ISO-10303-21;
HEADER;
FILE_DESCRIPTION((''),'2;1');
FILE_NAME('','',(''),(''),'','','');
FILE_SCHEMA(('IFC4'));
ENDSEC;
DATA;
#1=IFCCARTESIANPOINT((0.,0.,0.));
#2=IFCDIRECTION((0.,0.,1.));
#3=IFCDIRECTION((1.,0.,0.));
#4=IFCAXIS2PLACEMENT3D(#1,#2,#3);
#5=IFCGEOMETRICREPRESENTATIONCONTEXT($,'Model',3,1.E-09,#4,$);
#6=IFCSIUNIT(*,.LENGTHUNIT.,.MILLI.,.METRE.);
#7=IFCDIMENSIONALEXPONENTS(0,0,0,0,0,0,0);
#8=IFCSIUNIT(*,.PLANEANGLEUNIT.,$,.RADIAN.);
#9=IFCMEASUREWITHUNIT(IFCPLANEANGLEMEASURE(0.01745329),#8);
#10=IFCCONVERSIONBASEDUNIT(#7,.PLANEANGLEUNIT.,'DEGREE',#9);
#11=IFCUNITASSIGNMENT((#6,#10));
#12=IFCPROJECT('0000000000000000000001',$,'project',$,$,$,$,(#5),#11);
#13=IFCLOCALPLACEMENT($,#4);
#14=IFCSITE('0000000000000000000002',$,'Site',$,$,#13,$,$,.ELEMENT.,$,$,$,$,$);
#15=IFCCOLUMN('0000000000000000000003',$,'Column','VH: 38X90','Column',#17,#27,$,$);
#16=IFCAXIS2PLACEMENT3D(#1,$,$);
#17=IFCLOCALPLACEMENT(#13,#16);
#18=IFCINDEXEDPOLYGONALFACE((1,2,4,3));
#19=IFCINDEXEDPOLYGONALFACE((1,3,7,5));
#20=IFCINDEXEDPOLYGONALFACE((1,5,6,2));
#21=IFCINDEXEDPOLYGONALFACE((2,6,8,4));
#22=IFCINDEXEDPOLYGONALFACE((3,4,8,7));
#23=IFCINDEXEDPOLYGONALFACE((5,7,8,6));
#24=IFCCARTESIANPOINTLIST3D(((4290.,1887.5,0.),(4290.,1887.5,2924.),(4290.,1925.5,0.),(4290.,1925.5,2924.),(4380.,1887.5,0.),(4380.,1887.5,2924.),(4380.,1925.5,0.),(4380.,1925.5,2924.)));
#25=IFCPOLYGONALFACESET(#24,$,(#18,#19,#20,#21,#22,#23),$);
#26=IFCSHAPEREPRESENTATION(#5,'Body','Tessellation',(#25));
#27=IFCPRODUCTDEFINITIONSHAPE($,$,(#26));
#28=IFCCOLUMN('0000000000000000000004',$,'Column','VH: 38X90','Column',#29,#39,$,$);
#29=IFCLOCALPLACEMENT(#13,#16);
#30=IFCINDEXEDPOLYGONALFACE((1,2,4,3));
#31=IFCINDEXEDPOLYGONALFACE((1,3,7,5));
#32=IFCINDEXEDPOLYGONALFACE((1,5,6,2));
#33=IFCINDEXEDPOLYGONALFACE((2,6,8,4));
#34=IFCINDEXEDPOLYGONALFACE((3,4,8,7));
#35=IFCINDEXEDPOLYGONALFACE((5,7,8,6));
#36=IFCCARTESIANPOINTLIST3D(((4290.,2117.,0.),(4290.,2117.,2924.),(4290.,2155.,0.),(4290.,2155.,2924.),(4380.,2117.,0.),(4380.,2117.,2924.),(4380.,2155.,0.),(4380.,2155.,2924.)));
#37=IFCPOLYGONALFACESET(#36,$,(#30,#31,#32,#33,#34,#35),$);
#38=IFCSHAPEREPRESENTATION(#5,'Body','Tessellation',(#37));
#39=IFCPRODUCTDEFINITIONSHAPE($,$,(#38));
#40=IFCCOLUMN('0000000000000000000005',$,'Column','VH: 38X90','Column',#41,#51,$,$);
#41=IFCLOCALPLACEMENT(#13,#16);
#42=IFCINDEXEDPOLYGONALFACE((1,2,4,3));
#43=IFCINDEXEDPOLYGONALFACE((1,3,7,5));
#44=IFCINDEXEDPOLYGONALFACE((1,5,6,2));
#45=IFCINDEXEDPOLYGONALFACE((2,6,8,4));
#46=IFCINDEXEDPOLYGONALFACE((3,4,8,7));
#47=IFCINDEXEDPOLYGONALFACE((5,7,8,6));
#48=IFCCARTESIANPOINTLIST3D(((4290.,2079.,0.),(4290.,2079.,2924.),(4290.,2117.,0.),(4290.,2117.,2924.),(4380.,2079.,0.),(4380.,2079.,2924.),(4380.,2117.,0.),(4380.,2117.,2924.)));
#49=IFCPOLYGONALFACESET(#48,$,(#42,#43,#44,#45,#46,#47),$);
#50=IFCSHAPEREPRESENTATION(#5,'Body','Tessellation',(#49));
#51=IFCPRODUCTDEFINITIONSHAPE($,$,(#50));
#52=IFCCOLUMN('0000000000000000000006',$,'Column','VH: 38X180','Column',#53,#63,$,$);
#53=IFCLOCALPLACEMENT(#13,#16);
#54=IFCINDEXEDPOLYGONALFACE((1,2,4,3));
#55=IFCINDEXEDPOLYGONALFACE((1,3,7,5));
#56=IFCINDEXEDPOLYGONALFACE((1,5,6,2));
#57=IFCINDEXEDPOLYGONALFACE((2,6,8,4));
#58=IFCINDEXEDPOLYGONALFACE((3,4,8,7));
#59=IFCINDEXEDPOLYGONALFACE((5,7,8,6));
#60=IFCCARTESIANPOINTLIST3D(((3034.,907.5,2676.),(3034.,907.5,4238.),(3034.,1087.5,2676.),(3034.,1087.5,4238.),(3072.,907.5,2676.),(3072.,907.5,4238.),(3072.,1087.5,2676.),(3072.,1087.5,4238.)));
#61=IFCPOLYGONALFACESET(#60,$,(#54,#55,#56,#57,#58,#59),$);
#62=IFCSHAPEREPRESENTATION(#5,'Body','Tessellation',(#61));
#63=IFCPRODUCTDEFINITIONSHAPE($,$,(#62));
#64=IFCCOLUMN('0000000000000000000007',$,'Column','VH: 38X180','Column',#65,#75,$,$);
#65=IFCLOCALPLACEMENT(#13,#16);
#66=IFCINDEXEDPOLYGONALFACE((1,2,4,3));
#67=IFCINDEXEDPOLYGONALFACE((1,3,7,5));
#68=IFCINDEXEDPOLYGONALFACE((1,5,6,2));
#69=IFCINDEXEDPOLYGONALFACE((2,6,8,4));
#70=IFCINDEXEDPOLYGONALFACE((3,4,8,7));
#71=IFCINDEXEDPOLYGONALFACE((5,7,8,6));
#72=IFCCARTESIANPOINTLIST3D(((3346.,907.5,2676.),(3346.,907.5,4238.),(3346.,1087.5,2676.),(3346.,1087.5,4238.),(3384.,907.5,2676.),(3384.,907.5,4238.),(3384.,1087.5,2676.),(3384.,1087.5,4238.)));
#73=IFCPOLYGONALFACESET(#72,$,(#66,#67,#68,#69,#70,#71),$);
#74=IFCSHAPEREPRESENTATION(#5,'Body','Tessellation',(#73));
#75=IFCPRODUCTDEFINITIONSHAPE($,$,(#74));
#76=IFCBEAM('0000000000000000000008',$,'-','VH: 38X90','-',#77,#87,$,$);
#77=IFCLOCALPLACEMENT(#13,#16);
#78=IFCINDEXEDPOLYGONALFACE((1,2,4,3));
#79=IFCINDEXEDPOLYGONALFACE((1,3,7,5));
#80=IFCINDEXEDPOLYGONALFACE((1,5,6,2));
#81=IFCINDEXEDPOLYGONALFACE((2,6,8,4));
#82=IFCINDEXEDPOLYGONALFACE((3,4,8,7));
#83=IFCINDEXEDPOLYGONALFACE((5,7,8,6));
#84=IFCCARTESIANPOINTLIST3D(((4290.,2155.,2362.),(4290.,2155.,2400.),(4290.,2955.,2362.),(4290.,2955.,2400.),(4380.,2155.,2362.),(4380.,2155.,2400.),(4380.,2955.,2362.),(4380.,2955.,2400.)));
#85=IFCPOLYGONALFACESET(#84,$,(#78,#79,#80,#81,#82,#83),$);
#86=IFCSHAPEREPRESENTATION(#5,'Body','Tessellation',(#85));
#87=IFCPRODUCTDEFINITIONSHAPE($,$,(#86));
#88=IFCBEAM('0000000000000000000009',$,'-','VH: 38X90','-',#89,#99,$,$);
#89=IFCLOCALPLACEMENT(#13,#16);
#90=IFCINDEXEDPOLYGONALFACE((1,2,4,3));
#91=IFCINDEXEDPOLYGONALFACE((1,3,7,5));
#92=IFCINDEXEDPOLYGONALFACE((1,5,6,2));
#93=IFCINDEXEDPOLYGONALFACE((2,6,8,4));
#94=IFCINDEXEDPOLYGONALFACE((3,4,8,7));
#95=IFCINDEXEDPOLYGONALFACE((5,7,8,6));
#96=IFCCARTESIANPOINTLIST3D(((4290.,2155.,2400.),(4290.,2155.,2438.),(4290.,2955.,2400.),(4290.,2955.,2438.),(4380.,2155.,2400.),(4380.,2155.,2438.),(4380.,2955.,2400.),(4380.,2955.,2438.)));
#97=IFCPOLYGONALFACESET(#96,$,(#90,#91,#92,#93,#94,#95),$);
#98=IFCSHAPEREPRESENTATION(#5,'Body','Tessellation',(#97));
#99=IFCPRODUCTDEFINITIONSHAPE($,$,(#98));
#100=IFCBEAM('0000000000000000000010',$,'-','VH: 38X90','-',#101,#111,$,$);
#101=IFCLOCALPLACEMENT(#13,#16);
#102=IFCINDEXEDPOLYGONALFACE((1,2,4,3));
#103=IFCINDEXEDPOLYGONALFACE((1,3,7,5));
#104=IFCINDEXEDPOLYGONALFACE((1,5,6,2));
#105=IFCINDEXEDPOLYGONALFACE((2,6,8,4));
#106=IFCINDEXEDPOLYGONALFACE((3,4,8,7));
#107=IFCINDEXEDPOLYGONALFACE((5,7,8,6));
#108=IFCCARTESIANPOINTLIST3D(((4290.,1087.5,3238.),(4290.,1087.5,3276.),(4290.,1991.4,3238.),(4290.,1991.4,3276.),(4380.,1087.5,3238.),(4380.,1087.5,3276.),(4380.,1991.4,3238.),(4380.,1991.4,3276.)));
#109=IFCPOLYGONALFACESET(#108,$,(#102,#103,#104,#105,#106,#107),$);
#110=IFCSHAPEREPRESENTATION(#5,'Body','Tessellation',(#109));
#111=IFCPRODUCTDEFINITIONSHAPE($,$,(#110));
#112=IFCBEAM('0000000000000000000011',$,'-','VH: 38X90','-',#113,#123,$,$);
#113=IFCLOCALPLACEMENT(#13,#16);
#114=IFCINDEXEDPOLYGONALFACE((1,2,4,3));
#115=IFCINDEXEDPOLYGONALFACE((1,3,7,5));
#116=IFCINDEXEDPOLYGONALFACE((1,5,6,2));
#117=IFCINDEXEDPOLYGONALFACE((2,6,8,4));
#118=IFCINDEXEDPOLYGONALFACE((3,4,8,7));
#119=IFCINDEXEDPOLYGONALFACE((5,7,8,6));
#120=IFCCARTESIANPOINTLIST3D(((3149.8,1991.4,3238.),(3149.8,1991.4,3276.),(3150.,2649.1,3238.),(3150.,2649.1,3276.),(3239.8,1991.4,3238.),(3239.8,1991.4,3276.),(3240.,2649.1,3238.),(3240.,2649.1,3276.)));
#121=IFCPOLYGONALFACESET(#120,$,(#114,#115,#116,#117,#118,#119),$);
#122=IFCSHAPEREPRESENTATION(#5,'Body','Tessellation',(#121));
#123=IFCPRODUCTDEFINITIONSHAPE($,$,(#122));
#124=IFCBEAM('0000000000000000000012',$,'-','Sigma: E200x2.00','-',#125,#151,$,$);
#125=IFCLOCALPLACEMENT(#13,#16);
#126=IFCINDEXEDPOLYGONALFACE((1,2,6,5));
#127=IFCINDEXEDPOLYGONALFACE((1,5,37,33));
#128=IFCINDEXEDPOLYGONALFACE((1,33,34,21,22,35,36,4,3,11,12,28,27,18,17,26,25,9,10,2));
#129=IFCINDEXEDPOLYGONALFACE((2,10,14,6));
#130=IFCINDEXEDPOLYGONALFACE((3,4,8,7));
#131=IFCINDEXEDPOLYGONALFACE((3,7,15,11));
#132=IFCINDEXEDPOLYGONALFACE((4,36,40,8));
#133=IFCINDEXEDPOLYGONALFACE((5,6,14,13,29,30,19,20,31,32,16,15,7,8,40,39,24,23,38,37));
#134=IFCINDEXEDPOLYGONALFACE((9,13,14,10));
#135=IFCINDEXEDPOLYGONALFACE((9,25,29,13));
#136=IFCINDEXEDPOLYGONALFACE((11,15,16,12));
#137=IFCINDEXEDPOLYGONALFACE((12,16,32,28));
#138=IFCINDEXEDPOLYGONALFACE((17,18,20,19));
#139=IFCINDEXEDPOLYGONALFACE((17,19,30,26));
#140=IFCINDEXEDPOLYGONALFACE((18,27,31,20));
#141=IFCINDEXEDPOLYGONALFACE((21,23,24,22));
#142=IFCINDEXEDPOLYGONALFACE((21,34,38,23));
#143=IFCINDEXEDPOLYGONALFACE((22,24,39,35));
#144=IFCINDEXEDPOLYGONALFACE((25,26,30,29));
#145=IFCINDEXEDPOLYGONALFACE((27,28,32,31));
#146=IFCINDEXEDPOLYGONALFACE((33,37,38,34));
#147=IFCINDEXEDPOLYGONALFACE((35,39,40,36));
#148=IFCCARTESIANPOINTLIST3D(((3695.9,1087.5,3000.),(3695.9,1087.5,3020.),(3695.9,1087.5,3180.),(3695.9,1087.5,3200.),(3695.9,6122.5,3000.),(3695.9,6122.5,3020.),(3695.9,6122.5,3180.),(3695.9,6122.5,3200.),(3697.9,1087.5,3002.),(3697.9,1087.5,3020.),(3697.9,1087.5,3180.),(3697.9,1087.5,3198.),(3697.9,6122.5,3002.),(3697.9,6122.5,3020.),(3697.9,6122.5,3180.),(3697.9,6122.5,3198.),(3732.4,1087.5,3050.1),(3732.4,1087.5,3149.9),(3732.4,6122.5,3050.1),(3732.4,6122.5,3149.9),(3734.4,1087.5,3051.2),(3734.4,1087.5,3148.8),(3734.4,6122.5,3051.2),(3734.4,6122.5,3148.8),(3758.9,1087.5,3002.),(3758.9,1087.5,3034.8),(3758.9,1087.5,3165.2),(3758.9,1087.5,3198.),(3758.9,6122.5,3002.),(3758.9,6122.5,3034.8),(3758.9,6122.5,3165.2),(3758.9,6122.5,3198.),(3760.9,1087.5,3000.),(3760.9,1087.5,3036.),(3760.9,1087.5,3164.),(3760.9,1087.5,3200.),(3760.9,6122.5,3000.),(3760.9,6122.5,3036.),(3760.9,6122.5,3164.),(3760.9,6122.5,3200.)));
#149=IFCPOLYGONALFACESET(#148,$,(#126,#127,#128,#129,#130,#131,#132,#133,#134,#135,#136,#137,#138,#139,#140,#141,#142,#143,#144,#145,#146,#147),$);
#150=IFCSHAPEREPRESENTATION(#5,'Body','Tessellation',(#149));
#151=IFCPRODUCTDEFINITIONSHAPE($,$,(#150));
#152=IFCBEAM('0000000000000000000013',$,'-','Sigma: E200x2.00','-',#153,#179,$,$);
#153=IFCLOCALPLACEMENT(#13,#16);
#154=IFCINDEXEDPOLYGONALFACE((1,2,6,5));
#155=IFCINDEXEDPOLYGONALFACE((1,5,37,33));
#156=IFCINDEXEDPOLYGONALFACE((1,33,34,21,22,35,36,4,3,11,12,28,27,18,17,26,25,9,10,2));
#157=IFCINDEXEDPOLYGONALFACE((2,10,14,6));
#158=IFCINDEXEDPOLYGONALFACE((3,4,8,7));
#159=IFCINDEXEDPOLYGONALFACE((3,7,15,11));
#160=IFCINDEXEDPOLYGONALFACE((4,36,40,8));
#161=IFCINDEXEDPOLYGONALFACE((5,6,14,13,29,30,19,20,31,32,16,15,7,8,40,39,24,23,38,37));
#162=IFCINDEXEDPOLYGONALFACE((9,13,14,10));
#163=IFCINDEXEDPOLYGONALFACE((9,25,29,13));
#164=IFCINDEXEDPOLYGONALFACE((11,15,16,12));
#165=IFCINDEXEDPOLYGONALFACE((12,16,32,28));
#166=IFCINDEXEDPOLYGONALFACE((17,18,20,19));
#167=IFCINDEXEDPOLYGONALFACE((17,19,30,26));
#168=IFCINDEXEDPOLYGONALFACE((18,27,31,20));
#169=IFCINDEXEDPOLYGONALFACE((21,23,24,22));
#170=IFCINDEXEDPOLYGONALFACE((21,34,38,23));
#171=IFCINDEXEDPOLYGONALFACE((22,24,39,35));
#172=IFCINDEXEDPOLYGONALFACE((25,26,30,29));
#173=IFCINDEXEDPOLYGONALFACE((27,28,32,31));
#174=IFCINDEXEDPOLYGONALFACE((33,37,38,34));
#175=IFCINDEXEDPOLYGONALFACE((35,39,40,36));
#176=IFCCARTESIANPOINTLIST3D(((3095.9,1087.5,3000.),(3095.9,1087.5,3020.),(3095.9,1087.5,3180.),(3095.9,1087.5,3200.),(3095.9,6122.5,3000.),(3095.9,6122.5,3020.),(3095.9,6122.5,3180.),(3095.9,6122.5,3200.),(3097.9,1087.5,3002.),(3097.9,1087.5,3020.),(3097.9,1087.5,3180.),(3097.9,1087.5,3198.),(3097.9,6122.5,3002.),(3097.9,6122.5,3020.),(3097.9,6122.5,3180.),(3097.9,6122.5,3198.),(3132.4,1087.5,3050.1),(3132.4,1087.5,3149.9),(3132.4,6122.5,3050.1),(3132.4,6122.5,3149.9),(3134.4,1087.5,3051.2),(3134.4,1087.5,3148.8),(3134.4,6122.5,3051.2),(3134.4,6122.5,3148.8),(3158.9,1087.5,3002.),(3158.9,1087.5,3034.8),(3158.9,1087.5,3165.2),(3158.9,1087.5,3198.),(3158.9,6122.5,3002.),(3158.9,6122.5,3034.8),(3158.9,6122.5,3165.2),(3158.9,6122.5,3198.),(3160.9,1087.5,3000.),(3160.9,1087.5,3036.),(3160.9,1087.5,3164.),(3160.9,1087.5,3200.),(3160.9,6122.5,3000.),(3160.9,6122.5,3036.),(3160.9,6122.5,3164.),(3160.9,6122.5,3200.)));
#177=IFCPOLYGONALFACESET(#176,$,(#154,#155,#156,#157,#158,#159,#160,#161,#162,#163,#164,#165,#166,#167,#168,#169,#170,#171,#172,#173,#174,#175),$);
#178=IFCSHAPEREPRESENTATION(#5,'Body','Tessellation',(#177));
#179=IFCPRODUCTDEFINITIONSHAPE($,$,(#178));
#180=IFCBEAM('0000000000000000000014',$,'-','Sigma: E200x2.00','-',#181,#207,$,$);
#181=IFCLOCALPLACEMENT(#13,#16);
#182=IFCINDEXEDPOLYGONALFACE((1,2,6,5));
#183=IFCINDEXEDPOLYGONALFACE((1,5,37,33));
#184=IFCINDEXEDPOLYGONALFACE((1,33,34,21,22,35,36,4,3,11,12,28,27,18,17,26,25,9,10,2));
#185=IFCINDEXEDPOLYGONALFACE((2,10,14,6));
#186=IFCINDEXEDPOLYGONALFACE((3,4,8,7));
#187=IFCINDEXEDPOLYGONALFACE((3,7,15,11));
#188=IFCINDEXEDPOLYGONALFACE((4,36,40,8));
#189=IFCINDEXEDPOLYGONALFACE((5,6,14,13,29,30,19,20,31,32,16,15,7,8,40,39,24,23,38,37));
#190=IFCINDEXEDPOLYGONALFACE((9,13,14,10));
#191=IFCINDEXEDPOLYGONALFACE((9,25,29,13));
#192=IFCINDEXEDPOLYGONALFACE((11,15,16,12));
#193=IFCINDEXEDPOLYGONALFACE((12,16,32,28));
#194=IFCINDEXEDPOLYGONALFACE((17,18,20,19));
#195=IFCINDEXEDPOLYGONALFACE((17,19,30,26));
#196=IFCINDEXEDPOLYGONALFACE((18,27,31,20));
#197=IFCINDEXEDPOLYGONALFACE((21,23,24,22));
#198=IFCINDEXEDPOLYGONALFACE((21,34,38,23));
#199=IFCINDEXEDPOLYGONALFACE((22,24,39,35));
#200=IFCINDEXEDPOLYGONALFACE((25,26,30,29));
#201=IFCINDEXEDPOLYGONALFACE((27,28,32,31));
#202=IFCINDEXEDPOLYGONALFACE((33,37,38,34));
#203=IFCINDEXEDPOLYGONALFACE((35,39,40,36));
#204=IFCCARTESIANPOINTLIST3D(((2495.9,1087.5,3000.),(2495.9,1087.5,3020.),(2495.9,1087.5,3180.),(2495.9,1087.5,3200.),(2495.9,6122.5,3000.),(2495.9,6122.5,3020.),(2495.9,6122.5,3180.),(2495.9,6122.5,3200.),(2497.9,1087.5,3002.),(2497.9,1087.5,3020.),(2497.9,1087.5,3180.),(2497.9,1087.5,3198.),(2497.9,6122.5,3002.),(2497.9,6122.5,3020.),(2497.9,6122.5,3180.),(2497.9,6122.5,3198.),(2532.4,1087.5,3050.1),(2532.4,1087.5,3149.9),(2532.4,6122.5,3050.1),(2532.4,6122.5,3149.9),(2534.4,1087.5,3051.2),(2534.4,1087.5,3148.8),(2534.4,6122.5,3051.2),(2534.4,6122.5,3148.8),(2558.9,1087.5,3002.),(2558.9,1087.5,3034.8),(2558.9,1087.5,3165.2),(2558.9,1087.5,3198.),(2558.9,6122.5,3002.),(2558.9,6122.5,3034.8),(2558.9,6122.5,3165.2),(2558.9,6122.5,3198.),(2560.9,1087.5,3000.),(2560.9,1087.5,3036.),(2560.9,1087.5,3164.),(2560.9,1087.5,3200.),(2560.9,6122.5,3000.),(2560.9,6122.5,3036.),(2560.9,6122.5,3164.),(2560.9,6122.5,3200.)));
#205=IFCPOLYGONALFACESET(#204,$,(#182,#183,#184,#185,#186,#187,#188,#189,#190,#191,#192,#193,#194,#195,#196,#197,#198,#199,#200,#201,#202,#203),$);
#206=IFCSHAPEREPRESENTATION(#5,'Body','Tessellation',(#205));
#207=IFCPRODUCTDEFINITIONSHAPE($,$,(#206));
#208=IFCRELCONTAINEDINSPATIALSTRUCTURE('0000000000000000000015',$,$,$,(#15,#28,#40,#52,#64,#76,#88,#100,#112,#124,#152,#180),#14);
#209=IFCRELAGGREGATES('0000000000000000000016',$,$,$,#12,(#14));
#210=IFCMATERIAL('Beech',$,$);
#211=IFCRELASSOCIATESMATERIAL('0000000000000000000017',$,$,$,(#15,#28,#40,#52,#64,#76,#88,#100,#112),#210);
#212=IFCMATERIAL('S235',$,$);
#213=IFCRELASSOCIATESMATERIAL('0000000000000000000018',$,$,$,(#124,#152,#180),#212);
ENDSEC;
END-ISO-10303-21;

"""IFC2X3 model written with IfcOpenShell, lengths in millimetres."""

from ifc_helpers import new_model, entity, si_unit, converted_unit, frame, origin, origin_with_axes, origin_2d, place, context, project, spatial, polyline, rectangle, outline, extrude, material, element, save


model = new_model("IFC2X3")

# Units and contexts
model_context = context("Model", 3, precision=1e-09, world=origin_with_axes())
ifc_project = project(units=[si_unit("LENGTHUNIT", "METRE", prefix="MILLI"), converted_unit("PLANEANGLEUNIT", "DEGREE", entity("IfcPlaneAngleMeasure", 0.01745329), si_unit("PLANEANGLEUNIT", "RADIAN"), dimensions=[0, 0, 0, 0, 0, 0, 0])], contexts=[model_context])

# Site
site_placement = place(None, origin_with_axes())
site = spatial("IfcSite", under=ifc_project, at=site_placement, Name="Site", CompositionType="ELEMENT")

# Columns
ifc_material_1 = material(Name="Beech")
for number, where, z_axis, x_axis, name in (
    (1, (4335.0, 1906.5, 0.0), (0.0, 0.0, -1.0), (0.0, -1.0, 0.0), "Column"),
    (2, (4335.0, 2136.0, 0.0), (0.0, 0.0, -1.0), (0.0, -1.0, 0.0), "Column"),
    (3, (4335.0, 2098.0, 0.0), (0.0, 0.0, -1.0), (0.0, -1.0, 0.0), "Column"),
):
    element("IfcColumn", number, at=place(None, frame(where, z_axis=z_axis, x_axis=x_axis)), inside=site, material=ifc_material_1, Name=name, Description="VH: 38X90", ObjectType="Column", context=model_context, shape_type="SweptSolid", body=[
        extrude(rectangle(XDim=38.0, YDim=90.0, at=origin_2d()), origin(), (0.0, 0.0, -1.0), 2924.0),
    ])
for number, where, z_axis, x_axis, name in (
    (4, (3053.0, 997.5, 2676.0), (0.0, 0.0, -1.0), (-1.0, 0.0, 0.0), "Column"),
    (5, (3365.0, 997.5, 2676.0), (0.0, 0.0, -1.0), (1.0, 0.0, 0.0), "Column"),
):
    element("IfcColumn", number, at=place(None, frame(where, z_axis=z_axis, x_axis=x_axis)), inside=site, material=ifc_material_1, Name=name, Description="VH: 38X180", ObjectType="Column", context=model_context, shape_type="SweptSolid", body=[
        extrude(rectangle(XDim=38.0, YDim=180.0, at=origin_2d()), origin(), (0.0, 0.0, -1.0), 1562.0),
    ])

# Beams
for number, where, z_axis, x_axis, name in (
    (6, (4335.0, 2155.0, 2381.0), (0.000033, -1.0, 0.0), (0.0, 0.0, -1.0), "-"),
    (7, (4335.0, 2155.0, 2419.0), (0.000033, -1.0, 0.0), (0.0, 0.0, -1.0), "-"),
):
    element("IfcBeam", number, at=place(None, frame(where, z_axis=z_axis, x_axis=x_axis)), inside=site, material=ifc_material_1, Name=name, Description="VH: 38X90", ObjectType="-", context=model_context, shape_type="SweptSolid", body=[
        extrude(rectangle(XDim=38.0, YDim=90.0, at=origin_2d()), origin(), (0.0, 0.0, -1.0), 800.0),
    ])
beam_1_placement = place(None, frame((4335.0, 1991.4, 3257.0), z_axis=(0.0, 1.0, 0.0), x_axis=(0.0, 0.0, -1.0)))
element("IfcBeam", 8, at=beam_1_placement, inside=site, material=ifc_material_1, Name="-", Description="VH: 38X90", ObjectType="-", context=model_context, shape_type="SweptSolid", body=[
    extrude(rectangle(XDim=38.0, YDim=90.0, at=origin_2d()), origin(), (0.0, 0.0, -1.0), 903.9),
])
beam_2_placement = place(None, frame((3195.0, 2649.1, 3257.0), z_axis=(0.000326, 1.0, 0.0), x_axis=(0.0, 0.0, -1.0)))
element("IfcBeam", 9, at=beam_2_placement, inside=site, material=ifc_material_1, Name="-", Description="VH: 38X90", ObjectType="-", context=model_context, shape_type="SweptSolid", body=[
    extrude(rectangle(XDim=38.0, YDim=90.0, at=origin_2d()), origin(), (0.0, 0.0, -1.0), 657.7),
])
ifc_material_2 = material(Name="S235")
for number, where, z_axis, x_axis, name in (
    (10, (3735.0, 1087.5, 3100.0), (0.0, 1.0, 0.0), (-1.0, 0.0, 0.0), "-"),
    (11, (3135.0, 1087.5, 3100.0), (0.0, 1.0, 0.0), (-1.0, 0.0, 0.0), "-"),
    (12, (2535.0, 1087.5, 3100.0), (0.0, 1.0, 0.0), (-1.0, 0.0, 0.0), "-"),
):
    element("IfcBeam", number, at=place(None, frame(where, z_axis=z_axis, x_axis=x_axis)), inside=site, material=ifc_material_2, Name=name, Description="Sigma: E200x2.00", ObjectType="-", context=model_context, shape_type="SweptSolid", body=[
        extrude(outline(polyline([(39.1, -100.0), (39.1, -80.0), (37.1, -80.0), (37.1, -98.0), (-23.9, -98.0), (-23.9, -65.2), (2.6, -49.9), (2.6, 49.9), (-23.9, 65.2), (-23.9, 98.0), (37.1, 98.0), (37.1, 80.0), (39.1, 80.0), (39.1, 100.0), (-25.9, 100.0), (-25.9, 64.0), (0.6, 48.8), (0.6, -48.8), (-25.9, -64.0), (-25.9, -100.0), (39.1, -100.0)])), origin(), (0.0, 0.0, 1.0), 5035.0),
    ])

save(model, "model.ifc")
